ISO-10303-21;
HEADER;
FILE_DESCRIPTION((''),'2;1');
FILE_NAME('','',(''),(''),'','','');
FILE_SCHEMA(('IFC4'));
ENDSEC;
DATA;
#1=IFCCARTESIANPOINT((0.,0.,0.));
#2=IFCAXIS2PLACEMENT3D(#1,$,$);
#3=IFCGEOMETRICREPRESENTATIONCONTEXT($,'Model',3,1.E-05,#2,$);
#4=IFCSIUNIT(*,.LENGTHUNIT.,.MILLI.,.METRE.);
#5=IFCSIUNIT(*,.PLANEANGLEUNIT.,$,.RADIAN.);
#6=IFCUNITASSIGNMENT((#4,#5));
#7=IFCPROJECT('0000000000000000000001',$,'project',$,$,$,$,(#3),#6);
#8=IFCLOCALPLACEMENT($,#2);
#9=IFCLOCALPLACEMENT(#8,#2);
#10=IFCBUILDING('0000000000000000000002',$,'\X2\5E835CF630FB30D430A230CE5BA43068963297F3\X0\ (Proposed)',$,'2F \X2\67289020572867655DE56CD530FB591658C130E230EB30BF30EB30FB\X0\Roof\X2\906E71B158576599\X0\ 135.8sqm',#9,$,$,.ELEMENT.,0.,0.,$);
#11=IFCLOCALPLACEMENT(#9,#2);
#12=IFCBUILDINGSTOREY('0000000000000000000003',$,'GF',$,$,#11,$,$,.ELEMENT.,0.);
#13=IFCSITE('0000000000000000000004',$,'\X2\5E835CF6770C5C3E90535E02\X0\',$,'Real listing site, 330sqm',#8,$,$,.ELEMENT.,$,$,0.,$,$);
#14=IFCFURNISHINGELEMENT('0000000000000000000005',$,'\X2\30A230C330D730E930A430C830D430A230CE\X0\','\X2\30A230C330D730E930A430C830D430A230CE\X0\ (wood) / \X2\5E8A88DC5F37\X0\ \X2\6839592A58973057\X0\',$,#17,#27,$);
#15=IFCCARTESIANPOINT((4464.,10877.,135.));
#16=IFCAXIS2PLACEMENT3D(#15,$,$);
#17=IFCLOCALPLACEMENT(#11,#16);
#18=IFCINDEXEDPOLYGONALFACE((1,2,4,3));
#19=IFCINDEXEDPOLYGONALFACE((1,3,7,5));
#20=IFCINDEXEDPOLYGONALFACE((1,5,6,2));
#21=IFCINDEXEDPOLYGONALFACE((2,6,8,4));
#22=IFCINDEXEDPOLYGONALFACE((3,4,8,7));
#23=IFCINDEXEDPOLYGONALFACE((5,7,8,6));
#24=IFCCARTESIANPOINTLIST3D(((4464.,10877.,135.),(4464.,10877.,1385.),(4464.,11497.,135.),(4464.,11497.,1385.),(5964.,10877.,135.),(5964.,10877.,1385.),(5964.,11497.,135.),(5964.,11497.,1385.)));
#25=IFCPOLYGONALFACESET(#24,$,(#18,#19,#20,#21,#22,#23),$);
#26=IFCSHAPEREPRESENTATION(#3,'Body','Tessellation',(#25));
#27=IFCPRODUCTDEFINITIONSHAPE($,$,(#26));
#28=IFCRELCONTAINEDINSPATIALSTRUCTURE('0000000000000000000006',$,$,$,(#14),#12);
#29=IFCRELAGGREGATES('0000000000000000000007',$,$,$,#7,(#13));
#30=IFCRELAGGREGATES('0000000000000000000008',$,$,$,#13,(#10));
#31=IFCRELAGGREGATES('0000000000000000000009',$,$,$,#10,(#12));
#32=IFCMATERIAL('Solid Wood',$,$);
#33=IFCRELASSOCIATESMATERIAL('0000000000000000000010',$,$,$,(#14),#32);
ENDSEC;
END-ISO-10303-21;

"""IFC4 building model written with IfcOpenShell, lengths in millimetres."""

from ifc_helpers import new_model, si_unit, frame, frame_2d, origin, place, context, project, spatial, rectangle, extrude, material, element, save


model = new_model("IFC4")

# Units and contexts
model_context = context("Model", 3, precision=1e-05, world=origin())
ifc_project = project(units=[si_unit("LENGTHUNIT", "METRE", prefix="MILLI"), si_unit("PLANEANGLEUNIT", "RADIAN")], contexts=[model_context])

# Site, building, storey
site_placement = place(None, origin())
site = spatial("IfcSite", under=ifc_project, at=site_placement, Name="広島県尾道市", ObjectType="Real listing site, 330sqm", CompositionType="ELEMENT", RefElevation=0.0)
building_placement = place(site_placement, origin())
building = spatial("IfcBuilding", under=site, at=building_placement, Name="広島・ピアノ室と防音 (Proposed)", ObjectType="2F 木造在来工法・外壁モルタル・Roof遮熱塗料 135.8sqm", CompositionType="ELEMENT", ElevationOfRefHeight=0.0, ElevationOfTerrain=0.0)
storey_placement = place(building_placement, origin())
storey = spatial("IfcBuildingStorey", under=building, at=storey_placement, Name="GF", CompositionType="ELEMENT", Elevation=0.0)

# Shared definitions
ifc_material_1 = material(Name="Solid Wood")

# Furnishing element
furnishing_1_placement = place(storey_placement, frame((4464.0, 10877.0, 135.0)))
element("IfcFurnishingElement", 1, at=furnishing_1_placement, inside=storey, material=ifc_material_1, Name="アップライトピアノ", Description="アップライトピアノ (wood) / 床補強 根太増し", context=model_context, shape_type="SweptSolid", body=[
    extrude(rectangle(XDim=1500.0, YDim=620.0, at=frame_2d((750.0, 310.0))), frame((4464.0, 10877.0, 135.0)), (0.0, 0.0, 1.0), 1250.0),
])

save(model, "model.ifc")
